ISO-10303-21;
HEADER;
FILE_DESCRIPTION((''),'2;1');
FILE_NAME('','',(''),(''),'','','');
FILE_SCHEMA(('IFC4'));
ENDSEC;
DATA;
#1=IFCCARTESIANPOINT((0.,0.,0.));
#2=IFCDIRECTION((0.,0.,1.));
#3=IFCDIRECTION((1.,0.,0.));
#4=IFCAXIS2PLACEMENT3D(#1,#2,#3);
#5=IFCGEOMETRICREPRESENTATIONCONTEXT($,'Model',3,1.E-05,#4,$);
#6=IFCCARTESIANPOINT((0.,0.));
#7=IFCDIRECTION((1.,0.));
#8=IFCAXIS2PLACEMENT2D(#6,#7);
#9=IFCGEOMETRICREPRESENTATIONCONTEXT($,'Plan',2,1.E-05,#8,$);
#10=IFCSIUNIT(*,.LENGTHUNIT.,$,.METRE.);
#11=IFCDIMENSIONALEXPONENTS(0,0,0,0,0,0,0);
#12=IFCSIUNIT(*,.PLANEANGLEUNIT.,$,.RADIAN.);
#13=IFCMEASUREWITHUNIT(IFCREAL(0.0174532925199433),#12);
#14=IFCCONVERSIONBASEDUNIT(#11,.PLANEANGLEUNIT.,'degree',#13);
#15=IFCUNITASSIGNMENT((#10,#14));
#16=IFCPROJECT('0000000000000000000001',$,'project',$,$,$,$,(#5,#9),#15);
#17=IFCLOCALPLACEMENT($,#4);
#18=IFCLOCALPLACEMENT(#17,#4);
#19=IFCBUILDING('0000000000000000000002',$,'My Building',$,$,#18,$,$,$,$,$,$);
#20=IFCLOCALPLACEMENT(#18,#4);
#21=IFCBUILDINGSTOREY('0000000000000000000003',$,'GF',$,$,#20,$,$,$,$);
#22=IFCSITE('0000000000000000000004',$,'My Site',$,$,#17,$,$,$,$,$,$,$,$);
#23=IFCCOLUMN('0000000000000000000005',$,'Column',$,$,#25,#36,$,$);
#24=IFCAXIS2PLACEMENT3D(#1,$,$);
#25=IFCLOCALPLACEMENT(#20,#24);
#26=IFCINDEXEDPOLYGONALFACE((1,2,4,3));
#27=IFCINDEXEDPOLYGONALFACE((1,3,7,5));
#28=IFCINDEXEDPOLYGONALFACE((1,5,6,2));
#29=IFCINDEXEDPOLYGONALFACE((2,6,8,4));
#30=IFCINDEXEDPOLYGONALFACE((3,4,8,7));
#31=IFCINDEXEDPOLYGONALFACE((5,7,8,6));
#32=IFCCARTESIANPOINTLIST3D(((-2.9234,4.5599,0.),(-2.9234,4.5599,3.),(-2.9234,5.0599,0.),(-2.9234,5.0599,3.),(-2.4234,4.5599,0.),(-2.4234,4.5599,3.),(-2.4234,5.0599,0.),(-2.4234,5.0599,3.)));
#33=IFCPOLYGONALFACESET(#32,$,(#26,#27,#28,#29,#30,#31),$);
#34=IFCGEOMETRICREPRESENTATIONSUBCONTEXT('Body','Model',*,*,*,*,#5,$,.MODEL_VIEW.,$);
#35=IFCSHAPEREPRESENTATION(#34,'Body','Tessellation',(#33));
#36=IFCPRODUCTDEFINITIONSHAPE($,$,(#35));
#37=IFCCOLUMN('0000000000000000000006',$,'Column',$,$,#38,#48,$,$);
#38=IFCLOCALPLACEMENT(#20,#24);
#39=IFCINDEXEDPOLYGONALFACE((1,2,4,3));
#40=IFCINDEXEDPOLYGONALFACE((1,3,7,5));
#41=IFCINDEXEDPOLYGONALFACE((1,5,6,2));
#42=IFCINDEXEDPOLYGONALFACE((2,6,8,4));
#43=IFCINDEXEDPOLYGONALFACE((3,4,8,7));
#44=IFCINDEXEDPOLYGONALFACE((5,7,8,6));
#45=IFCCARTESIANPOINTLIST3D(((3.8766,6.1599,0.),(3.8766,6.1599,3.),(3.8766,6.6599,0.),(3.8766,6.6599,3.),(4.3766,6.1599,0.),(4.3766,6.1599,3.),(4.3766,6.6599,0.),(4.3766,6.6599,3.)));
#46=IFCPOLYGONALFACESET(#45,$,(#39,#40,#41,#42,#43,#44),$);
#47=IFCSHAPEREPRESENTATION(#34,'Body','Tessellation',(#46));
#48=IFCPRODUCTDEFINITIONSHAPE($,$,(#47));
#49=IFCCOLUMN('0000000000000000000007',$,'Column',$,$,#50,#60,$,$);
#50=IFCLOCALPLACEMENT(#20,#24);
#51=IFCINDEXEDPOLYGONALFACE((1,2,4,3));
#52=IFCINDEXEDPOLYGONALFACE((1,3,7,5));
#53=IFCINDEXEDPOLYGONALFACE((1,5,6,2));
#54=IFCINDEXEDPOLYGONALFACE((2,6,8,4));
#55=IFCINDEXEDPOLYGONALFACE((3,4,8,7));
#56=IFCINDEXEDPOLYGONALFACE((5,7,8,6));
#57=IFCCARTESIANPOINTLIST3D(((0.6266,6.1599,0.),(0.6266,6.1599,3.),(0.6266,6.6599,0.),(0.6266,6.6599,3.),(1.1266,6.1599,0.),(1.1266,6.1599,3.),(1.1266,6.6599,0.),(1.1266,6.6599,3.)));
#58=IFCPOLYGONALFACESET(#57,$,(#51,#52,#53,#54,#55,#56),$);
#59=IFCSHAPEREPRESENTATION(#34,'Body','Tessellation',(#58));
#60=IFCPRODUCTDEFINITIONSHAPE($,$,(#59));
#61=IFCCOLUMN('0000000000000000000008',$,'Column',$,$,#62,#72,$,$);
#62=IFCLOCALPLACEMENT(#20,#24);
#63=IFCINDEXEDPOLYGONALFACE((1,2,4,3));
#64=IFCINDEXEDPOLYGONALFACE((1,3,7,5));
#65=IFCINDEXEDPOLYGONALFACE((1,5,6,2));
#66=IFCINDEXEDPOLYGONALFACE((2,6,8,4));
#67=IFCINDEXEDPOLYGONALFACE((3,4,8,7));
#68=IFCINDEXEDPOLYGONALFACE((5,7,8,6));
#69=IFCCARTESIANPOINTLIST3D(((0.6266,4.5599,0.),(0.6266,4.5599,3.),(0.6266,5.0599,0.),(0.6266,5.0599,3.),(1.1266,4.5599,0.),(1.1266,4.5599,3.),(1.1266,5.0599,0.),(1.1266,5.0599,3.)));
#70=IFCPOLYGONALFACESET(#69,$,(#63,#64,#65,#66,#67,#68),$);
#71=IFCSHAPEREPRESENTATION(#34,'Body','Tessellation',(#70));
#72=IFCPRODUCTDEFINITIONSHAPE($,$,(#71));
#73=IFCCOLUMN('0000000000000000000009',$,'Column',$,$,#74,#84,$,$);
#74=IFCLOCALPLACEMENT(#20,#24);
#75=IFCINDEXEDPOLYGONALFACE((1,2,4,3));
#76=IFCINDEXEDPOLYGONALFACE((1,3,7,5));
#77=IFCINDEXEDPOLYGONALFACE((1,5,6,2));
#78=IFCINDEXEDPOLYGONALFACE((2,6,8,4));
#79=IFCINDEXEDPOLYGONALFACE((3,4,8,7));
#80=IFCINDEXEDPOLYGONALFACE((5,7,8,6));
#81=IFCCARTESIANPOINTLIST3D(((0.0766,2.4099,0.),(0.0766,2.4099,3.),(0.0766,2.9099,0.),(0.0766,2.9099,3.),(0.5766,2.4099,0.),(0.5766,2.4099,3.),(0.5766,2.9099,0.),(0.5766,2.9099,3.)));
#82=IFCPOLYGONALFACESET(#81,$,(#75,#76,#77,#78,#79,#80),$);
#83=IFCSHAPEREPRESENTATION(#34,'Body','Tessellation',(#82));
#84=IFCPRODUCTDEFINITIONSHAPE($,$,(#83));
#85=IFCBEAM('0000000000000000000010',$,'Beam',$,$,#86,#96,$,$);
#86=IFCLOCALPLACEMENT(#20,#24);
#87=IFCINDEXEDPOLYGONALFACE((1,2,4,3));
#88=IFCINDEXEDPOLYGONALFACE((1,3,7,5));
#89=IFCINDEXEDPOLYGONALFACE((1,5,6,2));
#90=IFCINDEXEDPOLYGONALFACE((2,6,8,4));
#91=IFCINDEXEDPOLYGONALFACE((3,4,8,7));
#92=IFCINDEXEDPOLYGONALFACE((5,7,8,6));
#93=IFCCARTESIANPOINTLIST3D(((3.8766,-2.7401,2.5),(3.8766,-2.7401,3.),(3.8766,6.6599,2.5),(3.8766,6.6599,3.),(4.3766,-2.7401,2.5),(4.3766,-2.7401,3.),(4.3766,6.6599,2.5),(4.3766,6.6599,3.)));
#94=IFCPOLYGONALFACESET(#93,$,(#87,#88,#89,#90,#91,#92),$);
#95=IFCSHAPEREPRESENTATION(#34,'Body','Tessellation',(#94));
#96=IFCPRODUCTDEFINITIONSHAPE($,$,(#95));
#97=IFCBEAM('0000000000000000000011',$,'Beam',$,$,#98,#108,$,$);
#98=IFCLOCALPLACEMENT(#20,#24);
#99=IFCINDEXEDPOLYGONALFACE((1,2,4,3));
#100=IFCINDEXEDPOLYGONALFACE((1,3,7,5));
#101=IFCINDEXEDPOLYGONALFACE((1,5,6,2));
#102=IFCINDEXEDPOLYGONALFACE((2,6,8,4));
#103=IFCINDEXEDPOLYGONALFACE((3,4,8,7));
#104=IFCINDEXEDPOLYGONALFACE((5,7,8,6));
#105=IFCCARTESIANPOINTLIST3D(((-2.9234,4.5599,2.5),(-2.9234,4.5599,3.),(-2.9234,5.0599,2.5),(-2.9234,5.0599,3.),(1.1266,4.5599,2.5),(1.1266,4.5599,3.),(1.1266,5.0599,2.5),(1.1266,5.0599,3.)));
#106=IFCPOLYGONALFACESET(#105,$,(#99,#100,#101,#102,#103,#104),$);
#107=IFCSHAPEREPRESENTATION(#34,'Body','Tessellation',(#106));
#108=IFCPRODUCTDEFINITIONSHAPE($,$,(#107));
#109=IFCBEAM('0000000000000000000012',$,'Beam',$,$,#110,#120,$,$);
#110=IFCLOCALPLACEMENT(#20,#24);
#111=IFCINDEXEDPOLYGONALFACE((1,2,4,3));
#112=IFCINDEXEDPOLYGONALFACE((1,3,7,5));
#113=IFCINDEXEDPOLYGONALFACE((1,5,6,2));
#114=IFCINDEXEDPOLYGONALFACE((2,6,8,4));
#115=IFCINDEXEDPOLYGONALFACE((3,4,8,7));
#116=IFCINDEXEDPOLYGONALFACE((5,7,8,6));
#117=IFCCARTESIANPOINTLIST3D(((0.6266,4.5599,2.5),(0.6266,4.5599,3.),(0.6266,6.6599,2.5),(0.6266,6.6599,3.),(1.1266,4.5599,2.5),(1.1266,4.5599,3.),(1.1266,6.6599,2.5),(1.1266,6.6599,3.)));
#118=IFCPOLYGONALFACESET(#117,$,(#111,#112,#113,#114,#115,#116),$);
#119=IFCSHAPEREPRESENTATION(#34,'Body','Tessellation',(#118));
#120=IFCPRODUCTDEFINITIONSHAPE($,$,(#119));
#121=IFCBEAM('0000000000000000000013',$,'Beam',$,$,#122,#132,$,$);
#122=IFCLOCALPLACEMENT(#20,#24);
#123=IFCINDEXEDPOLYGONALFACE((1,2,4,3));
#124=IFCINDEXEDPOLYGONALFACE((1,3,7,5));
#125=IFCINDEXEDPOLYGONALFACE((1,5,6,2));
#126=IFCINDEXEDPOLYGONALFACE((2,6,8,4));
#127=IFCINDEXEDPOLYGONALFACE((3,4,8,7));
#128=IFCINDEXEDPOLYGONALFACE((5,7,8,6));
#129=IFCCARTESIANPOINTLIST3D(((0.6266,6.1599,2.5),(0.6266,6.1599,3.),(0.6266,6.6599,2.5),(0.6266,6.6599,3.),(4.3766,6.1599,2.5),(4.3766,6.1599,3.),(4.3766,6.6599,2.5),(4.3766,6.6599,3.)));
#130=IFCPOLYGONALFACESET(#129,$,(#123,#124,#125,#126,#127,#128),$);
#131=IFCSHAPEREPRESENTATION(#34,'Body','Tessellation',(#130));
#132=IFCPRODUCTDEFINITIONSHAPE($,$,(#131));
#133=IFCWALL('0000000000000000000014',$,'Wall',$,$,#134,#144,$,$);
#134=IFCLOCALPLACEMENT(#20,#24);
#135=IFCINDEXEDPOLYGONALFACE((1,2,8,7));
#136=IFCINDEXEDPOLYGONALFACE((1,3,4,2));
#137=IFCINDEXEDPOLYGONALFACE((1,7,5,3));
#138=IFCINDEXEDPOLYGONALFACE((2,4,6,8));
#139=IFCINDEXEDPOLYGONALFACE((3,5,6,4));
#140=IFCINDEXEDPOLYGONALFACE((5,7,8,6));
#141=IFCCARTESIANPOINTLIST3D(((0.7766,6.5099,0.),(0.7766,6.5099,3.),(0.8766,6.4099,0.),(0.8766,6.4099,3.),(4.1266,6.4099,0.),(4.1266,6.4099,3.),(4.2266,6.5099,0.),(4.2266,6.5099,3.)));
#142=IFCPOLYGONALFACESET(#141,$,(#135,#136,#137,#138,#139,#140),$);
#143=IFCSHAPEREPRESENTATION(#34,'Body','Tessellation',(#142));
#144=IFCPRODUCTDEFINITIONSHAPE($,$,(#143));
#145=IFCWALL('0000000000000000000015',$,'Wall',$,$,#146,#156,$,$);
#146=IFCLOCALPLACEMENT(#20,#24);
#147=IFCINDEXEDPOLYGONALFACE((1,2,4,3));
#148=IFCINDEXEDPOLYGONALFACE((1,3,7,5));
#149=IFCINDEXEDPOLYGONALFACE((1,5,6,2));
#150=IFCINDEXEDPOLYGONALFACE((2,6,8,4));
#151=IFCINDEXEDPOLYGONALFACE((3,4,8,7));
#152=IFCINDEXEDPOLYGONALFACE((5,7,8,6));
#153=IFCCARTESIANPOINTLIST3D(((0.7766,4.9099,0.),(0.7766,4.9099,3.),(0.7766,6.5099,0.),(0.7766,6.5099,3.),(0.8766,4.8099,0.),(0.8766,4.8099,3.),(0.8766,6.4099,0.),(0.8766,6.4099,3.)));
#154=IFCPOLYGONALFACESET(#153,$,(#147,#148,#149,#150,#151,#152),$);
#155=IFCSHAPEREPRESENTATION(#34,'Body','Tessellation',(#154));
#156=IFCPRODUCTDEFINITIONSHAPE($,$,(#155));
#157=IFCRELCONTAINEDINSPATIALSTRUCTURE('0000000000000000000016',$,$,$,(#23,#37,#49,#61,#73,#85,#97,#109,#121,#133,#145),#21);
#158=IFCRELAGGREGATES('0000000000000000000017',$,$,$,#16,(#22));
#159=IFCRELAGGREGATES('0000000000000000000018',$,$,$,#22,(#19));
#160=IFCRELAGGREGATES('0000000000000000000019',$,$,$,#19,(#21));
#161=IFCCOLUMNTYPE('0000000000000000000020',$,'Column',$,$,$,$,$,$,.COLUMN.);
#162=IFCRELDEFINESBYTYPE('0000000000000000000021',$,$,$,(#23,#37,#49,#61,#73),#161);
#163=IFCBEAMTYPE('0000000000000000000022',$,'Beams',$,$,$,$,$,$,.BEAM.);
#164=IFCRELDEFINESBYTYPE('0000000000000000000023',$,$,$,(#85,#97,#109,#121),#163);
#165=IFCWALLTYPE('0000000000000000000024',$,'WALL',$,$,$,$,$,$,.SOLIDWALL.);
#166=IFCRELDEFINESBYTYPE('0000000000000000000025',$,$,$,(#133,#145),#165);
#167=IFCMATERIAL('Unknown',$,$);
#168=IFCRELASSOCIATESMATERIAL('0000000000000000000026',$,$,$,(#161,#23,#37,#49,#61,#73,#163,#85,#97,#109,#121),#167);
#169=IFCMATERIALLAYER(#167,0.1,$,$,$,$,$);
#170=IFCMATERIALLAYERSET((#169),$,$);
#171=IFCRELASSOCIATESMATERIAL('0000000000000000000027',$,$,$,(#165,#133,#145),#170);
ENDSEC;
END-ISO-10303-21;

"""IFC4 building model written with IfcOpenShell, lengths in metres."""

from ifc_helpers import new_model, entity, si_unit, converted_unit, frame, origin_with_axes, origin_2d_with_axis, place, context, subcontext, project, spatial, line, indexed_curve, rectangle, outline, extrude, material, layer, layer_set, layer_usage, material_profile, profile_set, profile_usage, type_object, element, save


model = new_model("IFC4")

# Units and contexts
model_context = context("Model", 3, precision=1e-05, world=origin_with_axes())
plan_context = context("Plan", 2, precision=1e-05, world=origin_2d_with_axis())
body_context_1 = subcontext(model_context, "Body", "Model", "MODEL_VIEW")
ifc_project = project(units=[si_unit("LENGTHUNIT", "METRE"), converted_unit("PLANEANGLEUNIT", "degree", entity("IfcReal", 0.0174532925199433), si_unit("PLANEANGLEUNIT", "RADIAN"), dimensions=[0, 0, 0, 0, 0, 0, 0])], contexts=[model_context, plan_context])

# Site, building, storey
site_placement = place(None, origin_with_axes())
site = spatial("IfcSite", under=ifc_project, at=site_placement, Name="My Site")
building_placement = place(site_placement, origin_with_axes())
building = spatial("IfcBuilding", under=site, at=building_placement, Name="My Building")
storey_placement = place(building_placement, origin_with_axes())
storey = spatial("IfcBuildingStorey", under=building, at=storey_placement, Name="GF")

# Columns
ifc_material = material(Name="Unknown")
ifc_material_profile_1 = material_profile(ifc_material, rectangle(XDim=0.5, YDim=0.5))
ifc_profile_set_1 = profile_set([ifc_material_profile_1])
ifc_profile_usage_1 = profile_usage(ifc_profile_set_1, cardinal=5)
column_type = type_object("IfcColumnType", Name="Column", PredefinedType="COLUMN", material=ifc_profile_set_1)
column_1_placement = place(storey_placement, frame((-2.6734, 4.8099, 0.0), z_axis=(0.0, 0.0, 1.0), x_axis=(1.0, 0.0, 0.0)))
element("IfcColumn", 1, at=column_1_placement, inside=storey, type_object=column_type, material=ifc_profile_usage_1, Name="Column", context=body_context_1, shape_type="SweptSolid", body=[
    extrude(rectangle(XDim=0.5, YDim=0.5), origin_with_axes(), (0.0, 0.0, 1.0), 3.0),
])
ifc_profile_usage_2 = profile_usage(ifc_profile_set_1, cardinal=5)
column_2_placement = place(storey_placement, frame((4.1266, 6.4099, 0.0), z_axis=(0.0, 0.0, 1.0), x_axis=(1.0, 0.0, 0.0)))
element("IfcColumn", 2, at=column_2_placement, inside=storey, type_object=column_type, material=ifc_profile_usage_2, Name="Column", context=body_context_1, shape_type="SweptSolid", body=[
    extrude(rectangle(XDim=0.5, YDim=0.5), origin_with_axes(), (0.0, 0.0, 1.0), 3.0),
])
ifc_profile_usage_3 = profile_usage(ifc_profile_set_1, cardinal=5)
column_3_placement = place(storey_placement, frame((0.8766, 6.4099, 0.0), z_axis=(0.0, 0.0, 1.0), x_axis=(1.0, 0.0, 0.0)))
element("IfcColumn", 3, at=column_3_placement, inside=storey, type_object=column_type, material=ifc_profile_usage_3, Name="Column", context=body_context_1, shape_type="SweptSolid", body=[
    extrude(rectangle(XDim=0.5, YDim=0.5), origin_with_axes(), (0.0, 0.0, 1.0), 3.0),
])
ifc_profile_usage_4 = profile_usage(ifc_profile_set_1, cardinal=5)
column_4_placement = place(storey_placement, frame((0.8766, 4.8099, 0.0), z_axis=(0.0, 0.0, 1.0), x_axis=(1.0, 0.0, 0.0)))
element("IfcColumn", 4, at=column_4_placement, inside=storey, type_object=column_type, material=ifc_profile_usage_4, Name="Column", context=body_context_1, shape_type="SweptSolid", body=[
    extrude(rectangle(XDim=0.5, YDim=0.5), origin_with_axes(), (0.0, 0.0, 1.0), 3.0),
])
ifc_profile_usage_5 = profile_usage(ifc_profile_set_1, cardinal=5)
column_5_placement = place(storey_placement, frame((0.3266, 2.6599, 0.0), z_axis=(0.0, 0.0, 1.0), x_axis=(1.0, 0.0, 0.0)))
element("IfcColumn", 5, at=column_5_placement, inside=storey, type_object=column_type, material=ifc_profile_usage_5, Name="Column", context=body_context_1, shape_type="SweptSolid", body=[
    extrude(rectangle(XDim=0.5, YDim=0.5), origin_with_axes(), (0.0, 0.0, 1.0), 3.0),
])

# Beams
ifc_material_profile_2 = material_profile(ifc_material, rectangle(XDim=0.5, YDim=0.5))
ifc_profile_set_2 = profile_set([ifc_material_profile_2])
ifc_profile_usage_6 = profile_usage(ifc_profile_set_2, cardinal=7)
beam_type = type_object("IfcBeamType", Name="Beams", PredefinedType="BEAM", material=ifc_profile_set_2)
beam_1_placement = place(storey_placement, frame((4.3766, 6.6599, 3.0), z_axis=(0.0, -1.0, 0.0), x_axis=(1.0, 0.0, 0.0)))
element("IfcBeam", 6, at=beam_1_placement, inside=storey, type_object=beam_type, material=ifc_profile_usage_6, Name="Beam", context=body_context_1, shape_type="SweptSolid", body=[
    extrude(rectangle(XDim=0.5, YDim=0.5), frame((-0.25, -0.25, 0.0), z_axis=(0.0, 0.0, 1.0), x_axis=(1.0, 0.0, 0.0)), (0.0, 0.0, 1.0), 9.4),
])
ifc_profile_usage_7 = profile_usage(ifc_profile_set_2, cardinal=7)
beam_2_placement = place(storey_placement, frame((-2.9234, 5.0599, 3.0), z_axis=(1.0, 0.0, 0.0), x_axis=(0.0, 1.0, 0.0)))
element("IfcBeam", 7, at=beam_2_placement, inside=storey, type_object=beam_type, material=ifc_profile_usage_7, Name="Beam", context=body_context_1, shape_type="SweptSolid", body=[
    extrude(rectangle(XDim=0.5, YDim=0.5), frame((-0.25, -0.25, 0.0), z_axis=(0.0, 0.0, 1.0), x_axis=(1.0, 0.0, 0.0)), (0.0, 0.0, 1.0), 4.05),
])
ifc_profile_usage_8 = profile_usage(ifc_profile_set_2, cardinal=7)
beam_3_placement = place(storey_placement, frame((0.6266, 4.5599, 3.0), z_axis=(0.0, 1.0, 0.0), x_axis=(-1.0, 0.0, 0.0)))
element("IfcBeam", 8, at=beam_3_placement, inside=storey, type_object=beam_type, material=ifc_profile_usage_8, Name="Beam", context=body_context_1, shape_type="SweptSolid", body=[
    extrude(rectangle(XDim=0.5, YDim=0.5), frame((-0.25, -0.25, 0.0), z_axis=(0.0, 0.0, 1.0), x_axis=(1.0, 0.0, 0.0)), (0.0, 0.0, 1.0), 2.1),
])
ifc_profile_usage_9 = profile_usage(ifc_profile_set_2, cardinal=7)
beam_4_placement = place(storey_placement, frame((0.6266, 6.6599, 3.0), z_axis=(1.0, 0.0, 0.0), x_axis=(0.0, 1.0, 0.0)))
element("IfcBeam", 9, at=beam_4_placement, inside=storey, type_object=beam_type, material=ifc_profile_usage_9, Name="Beam", context=body_context_1, shape_type="SweptSolid", body=[
    extrude(rectangle(XDim=0.5, YDim=0.5), frame((-0.25, -0.25, 0.0), z_axis=(0.0, 0.0, 1.0), x_axis=(1.0, 0.0, 0.0)), (0.0, 0.0, 1.0), 3.75),
])

# Walls
ifc_layer = layer(ifc_material, 0.1)
ifc_layer_set = layer_set([ifc_layer])
ifc_layer_usage_1 = layer_usage(ifc_layer_set, "AXIS2", "POSITIVE", 0.0)
wall_type = type_object("IfcWallType", Name="WALL", PredefinedType="SOLIDWALL", material=ifc_layer_set)
wall_1_placement = place(storey_placement, frame((4.2266, 6.5099, 0.0), z_axis=(0.0, 0.0, 1.0), x_axis=(-1.0, 0.0, 0.0)))
element("IfcWall", 10, at=wall_1_placement, inside=storey, type_object=wall_type, material=ifc_layer_usage_1, Name="Wall", context=body_context_1, shape_type="SweptSolid", body=[
    extrude(outline(indexed_curve([(0.0, 0.0), (0.1, 0.1), (3.35, 0.1), (3.45, 0.0)], segments=[line(1, 2, 3, 4, 1)])), origin_with_axes(), (0.0, 0.0, 1.0), 3.0),
])
ifc_layer_usage_2 = layer_usage(ifc_layer_set, "AXIS2", "POSITIVE", 0.0)
wall_2_placement = place(storey_placement, frame((0.7766, 6.5099, 0.0), z_axis=(0.0, 0.0, 1.0), x_axis=(0.0, -1.0, 0.0)))
element("IfcWall", 11, at=wall_2_placement, inside=storey, type_object=wall_type, material=ifc_layer_usage_2, Name="Wall", context=body_context_1, shape_type="SweptSolid", body=[
    extrude(outline(indexed_curve([(0.0, 0.0), (0.1, 0.1), (1.7, 0.1), (1.6, 0.0)], segments=[line(1, 2, 3, 4, 1)])), origin_with_axes(), (0.0, 0.0, 1.0), 3.0),
])

save(model, "model.ifc")
